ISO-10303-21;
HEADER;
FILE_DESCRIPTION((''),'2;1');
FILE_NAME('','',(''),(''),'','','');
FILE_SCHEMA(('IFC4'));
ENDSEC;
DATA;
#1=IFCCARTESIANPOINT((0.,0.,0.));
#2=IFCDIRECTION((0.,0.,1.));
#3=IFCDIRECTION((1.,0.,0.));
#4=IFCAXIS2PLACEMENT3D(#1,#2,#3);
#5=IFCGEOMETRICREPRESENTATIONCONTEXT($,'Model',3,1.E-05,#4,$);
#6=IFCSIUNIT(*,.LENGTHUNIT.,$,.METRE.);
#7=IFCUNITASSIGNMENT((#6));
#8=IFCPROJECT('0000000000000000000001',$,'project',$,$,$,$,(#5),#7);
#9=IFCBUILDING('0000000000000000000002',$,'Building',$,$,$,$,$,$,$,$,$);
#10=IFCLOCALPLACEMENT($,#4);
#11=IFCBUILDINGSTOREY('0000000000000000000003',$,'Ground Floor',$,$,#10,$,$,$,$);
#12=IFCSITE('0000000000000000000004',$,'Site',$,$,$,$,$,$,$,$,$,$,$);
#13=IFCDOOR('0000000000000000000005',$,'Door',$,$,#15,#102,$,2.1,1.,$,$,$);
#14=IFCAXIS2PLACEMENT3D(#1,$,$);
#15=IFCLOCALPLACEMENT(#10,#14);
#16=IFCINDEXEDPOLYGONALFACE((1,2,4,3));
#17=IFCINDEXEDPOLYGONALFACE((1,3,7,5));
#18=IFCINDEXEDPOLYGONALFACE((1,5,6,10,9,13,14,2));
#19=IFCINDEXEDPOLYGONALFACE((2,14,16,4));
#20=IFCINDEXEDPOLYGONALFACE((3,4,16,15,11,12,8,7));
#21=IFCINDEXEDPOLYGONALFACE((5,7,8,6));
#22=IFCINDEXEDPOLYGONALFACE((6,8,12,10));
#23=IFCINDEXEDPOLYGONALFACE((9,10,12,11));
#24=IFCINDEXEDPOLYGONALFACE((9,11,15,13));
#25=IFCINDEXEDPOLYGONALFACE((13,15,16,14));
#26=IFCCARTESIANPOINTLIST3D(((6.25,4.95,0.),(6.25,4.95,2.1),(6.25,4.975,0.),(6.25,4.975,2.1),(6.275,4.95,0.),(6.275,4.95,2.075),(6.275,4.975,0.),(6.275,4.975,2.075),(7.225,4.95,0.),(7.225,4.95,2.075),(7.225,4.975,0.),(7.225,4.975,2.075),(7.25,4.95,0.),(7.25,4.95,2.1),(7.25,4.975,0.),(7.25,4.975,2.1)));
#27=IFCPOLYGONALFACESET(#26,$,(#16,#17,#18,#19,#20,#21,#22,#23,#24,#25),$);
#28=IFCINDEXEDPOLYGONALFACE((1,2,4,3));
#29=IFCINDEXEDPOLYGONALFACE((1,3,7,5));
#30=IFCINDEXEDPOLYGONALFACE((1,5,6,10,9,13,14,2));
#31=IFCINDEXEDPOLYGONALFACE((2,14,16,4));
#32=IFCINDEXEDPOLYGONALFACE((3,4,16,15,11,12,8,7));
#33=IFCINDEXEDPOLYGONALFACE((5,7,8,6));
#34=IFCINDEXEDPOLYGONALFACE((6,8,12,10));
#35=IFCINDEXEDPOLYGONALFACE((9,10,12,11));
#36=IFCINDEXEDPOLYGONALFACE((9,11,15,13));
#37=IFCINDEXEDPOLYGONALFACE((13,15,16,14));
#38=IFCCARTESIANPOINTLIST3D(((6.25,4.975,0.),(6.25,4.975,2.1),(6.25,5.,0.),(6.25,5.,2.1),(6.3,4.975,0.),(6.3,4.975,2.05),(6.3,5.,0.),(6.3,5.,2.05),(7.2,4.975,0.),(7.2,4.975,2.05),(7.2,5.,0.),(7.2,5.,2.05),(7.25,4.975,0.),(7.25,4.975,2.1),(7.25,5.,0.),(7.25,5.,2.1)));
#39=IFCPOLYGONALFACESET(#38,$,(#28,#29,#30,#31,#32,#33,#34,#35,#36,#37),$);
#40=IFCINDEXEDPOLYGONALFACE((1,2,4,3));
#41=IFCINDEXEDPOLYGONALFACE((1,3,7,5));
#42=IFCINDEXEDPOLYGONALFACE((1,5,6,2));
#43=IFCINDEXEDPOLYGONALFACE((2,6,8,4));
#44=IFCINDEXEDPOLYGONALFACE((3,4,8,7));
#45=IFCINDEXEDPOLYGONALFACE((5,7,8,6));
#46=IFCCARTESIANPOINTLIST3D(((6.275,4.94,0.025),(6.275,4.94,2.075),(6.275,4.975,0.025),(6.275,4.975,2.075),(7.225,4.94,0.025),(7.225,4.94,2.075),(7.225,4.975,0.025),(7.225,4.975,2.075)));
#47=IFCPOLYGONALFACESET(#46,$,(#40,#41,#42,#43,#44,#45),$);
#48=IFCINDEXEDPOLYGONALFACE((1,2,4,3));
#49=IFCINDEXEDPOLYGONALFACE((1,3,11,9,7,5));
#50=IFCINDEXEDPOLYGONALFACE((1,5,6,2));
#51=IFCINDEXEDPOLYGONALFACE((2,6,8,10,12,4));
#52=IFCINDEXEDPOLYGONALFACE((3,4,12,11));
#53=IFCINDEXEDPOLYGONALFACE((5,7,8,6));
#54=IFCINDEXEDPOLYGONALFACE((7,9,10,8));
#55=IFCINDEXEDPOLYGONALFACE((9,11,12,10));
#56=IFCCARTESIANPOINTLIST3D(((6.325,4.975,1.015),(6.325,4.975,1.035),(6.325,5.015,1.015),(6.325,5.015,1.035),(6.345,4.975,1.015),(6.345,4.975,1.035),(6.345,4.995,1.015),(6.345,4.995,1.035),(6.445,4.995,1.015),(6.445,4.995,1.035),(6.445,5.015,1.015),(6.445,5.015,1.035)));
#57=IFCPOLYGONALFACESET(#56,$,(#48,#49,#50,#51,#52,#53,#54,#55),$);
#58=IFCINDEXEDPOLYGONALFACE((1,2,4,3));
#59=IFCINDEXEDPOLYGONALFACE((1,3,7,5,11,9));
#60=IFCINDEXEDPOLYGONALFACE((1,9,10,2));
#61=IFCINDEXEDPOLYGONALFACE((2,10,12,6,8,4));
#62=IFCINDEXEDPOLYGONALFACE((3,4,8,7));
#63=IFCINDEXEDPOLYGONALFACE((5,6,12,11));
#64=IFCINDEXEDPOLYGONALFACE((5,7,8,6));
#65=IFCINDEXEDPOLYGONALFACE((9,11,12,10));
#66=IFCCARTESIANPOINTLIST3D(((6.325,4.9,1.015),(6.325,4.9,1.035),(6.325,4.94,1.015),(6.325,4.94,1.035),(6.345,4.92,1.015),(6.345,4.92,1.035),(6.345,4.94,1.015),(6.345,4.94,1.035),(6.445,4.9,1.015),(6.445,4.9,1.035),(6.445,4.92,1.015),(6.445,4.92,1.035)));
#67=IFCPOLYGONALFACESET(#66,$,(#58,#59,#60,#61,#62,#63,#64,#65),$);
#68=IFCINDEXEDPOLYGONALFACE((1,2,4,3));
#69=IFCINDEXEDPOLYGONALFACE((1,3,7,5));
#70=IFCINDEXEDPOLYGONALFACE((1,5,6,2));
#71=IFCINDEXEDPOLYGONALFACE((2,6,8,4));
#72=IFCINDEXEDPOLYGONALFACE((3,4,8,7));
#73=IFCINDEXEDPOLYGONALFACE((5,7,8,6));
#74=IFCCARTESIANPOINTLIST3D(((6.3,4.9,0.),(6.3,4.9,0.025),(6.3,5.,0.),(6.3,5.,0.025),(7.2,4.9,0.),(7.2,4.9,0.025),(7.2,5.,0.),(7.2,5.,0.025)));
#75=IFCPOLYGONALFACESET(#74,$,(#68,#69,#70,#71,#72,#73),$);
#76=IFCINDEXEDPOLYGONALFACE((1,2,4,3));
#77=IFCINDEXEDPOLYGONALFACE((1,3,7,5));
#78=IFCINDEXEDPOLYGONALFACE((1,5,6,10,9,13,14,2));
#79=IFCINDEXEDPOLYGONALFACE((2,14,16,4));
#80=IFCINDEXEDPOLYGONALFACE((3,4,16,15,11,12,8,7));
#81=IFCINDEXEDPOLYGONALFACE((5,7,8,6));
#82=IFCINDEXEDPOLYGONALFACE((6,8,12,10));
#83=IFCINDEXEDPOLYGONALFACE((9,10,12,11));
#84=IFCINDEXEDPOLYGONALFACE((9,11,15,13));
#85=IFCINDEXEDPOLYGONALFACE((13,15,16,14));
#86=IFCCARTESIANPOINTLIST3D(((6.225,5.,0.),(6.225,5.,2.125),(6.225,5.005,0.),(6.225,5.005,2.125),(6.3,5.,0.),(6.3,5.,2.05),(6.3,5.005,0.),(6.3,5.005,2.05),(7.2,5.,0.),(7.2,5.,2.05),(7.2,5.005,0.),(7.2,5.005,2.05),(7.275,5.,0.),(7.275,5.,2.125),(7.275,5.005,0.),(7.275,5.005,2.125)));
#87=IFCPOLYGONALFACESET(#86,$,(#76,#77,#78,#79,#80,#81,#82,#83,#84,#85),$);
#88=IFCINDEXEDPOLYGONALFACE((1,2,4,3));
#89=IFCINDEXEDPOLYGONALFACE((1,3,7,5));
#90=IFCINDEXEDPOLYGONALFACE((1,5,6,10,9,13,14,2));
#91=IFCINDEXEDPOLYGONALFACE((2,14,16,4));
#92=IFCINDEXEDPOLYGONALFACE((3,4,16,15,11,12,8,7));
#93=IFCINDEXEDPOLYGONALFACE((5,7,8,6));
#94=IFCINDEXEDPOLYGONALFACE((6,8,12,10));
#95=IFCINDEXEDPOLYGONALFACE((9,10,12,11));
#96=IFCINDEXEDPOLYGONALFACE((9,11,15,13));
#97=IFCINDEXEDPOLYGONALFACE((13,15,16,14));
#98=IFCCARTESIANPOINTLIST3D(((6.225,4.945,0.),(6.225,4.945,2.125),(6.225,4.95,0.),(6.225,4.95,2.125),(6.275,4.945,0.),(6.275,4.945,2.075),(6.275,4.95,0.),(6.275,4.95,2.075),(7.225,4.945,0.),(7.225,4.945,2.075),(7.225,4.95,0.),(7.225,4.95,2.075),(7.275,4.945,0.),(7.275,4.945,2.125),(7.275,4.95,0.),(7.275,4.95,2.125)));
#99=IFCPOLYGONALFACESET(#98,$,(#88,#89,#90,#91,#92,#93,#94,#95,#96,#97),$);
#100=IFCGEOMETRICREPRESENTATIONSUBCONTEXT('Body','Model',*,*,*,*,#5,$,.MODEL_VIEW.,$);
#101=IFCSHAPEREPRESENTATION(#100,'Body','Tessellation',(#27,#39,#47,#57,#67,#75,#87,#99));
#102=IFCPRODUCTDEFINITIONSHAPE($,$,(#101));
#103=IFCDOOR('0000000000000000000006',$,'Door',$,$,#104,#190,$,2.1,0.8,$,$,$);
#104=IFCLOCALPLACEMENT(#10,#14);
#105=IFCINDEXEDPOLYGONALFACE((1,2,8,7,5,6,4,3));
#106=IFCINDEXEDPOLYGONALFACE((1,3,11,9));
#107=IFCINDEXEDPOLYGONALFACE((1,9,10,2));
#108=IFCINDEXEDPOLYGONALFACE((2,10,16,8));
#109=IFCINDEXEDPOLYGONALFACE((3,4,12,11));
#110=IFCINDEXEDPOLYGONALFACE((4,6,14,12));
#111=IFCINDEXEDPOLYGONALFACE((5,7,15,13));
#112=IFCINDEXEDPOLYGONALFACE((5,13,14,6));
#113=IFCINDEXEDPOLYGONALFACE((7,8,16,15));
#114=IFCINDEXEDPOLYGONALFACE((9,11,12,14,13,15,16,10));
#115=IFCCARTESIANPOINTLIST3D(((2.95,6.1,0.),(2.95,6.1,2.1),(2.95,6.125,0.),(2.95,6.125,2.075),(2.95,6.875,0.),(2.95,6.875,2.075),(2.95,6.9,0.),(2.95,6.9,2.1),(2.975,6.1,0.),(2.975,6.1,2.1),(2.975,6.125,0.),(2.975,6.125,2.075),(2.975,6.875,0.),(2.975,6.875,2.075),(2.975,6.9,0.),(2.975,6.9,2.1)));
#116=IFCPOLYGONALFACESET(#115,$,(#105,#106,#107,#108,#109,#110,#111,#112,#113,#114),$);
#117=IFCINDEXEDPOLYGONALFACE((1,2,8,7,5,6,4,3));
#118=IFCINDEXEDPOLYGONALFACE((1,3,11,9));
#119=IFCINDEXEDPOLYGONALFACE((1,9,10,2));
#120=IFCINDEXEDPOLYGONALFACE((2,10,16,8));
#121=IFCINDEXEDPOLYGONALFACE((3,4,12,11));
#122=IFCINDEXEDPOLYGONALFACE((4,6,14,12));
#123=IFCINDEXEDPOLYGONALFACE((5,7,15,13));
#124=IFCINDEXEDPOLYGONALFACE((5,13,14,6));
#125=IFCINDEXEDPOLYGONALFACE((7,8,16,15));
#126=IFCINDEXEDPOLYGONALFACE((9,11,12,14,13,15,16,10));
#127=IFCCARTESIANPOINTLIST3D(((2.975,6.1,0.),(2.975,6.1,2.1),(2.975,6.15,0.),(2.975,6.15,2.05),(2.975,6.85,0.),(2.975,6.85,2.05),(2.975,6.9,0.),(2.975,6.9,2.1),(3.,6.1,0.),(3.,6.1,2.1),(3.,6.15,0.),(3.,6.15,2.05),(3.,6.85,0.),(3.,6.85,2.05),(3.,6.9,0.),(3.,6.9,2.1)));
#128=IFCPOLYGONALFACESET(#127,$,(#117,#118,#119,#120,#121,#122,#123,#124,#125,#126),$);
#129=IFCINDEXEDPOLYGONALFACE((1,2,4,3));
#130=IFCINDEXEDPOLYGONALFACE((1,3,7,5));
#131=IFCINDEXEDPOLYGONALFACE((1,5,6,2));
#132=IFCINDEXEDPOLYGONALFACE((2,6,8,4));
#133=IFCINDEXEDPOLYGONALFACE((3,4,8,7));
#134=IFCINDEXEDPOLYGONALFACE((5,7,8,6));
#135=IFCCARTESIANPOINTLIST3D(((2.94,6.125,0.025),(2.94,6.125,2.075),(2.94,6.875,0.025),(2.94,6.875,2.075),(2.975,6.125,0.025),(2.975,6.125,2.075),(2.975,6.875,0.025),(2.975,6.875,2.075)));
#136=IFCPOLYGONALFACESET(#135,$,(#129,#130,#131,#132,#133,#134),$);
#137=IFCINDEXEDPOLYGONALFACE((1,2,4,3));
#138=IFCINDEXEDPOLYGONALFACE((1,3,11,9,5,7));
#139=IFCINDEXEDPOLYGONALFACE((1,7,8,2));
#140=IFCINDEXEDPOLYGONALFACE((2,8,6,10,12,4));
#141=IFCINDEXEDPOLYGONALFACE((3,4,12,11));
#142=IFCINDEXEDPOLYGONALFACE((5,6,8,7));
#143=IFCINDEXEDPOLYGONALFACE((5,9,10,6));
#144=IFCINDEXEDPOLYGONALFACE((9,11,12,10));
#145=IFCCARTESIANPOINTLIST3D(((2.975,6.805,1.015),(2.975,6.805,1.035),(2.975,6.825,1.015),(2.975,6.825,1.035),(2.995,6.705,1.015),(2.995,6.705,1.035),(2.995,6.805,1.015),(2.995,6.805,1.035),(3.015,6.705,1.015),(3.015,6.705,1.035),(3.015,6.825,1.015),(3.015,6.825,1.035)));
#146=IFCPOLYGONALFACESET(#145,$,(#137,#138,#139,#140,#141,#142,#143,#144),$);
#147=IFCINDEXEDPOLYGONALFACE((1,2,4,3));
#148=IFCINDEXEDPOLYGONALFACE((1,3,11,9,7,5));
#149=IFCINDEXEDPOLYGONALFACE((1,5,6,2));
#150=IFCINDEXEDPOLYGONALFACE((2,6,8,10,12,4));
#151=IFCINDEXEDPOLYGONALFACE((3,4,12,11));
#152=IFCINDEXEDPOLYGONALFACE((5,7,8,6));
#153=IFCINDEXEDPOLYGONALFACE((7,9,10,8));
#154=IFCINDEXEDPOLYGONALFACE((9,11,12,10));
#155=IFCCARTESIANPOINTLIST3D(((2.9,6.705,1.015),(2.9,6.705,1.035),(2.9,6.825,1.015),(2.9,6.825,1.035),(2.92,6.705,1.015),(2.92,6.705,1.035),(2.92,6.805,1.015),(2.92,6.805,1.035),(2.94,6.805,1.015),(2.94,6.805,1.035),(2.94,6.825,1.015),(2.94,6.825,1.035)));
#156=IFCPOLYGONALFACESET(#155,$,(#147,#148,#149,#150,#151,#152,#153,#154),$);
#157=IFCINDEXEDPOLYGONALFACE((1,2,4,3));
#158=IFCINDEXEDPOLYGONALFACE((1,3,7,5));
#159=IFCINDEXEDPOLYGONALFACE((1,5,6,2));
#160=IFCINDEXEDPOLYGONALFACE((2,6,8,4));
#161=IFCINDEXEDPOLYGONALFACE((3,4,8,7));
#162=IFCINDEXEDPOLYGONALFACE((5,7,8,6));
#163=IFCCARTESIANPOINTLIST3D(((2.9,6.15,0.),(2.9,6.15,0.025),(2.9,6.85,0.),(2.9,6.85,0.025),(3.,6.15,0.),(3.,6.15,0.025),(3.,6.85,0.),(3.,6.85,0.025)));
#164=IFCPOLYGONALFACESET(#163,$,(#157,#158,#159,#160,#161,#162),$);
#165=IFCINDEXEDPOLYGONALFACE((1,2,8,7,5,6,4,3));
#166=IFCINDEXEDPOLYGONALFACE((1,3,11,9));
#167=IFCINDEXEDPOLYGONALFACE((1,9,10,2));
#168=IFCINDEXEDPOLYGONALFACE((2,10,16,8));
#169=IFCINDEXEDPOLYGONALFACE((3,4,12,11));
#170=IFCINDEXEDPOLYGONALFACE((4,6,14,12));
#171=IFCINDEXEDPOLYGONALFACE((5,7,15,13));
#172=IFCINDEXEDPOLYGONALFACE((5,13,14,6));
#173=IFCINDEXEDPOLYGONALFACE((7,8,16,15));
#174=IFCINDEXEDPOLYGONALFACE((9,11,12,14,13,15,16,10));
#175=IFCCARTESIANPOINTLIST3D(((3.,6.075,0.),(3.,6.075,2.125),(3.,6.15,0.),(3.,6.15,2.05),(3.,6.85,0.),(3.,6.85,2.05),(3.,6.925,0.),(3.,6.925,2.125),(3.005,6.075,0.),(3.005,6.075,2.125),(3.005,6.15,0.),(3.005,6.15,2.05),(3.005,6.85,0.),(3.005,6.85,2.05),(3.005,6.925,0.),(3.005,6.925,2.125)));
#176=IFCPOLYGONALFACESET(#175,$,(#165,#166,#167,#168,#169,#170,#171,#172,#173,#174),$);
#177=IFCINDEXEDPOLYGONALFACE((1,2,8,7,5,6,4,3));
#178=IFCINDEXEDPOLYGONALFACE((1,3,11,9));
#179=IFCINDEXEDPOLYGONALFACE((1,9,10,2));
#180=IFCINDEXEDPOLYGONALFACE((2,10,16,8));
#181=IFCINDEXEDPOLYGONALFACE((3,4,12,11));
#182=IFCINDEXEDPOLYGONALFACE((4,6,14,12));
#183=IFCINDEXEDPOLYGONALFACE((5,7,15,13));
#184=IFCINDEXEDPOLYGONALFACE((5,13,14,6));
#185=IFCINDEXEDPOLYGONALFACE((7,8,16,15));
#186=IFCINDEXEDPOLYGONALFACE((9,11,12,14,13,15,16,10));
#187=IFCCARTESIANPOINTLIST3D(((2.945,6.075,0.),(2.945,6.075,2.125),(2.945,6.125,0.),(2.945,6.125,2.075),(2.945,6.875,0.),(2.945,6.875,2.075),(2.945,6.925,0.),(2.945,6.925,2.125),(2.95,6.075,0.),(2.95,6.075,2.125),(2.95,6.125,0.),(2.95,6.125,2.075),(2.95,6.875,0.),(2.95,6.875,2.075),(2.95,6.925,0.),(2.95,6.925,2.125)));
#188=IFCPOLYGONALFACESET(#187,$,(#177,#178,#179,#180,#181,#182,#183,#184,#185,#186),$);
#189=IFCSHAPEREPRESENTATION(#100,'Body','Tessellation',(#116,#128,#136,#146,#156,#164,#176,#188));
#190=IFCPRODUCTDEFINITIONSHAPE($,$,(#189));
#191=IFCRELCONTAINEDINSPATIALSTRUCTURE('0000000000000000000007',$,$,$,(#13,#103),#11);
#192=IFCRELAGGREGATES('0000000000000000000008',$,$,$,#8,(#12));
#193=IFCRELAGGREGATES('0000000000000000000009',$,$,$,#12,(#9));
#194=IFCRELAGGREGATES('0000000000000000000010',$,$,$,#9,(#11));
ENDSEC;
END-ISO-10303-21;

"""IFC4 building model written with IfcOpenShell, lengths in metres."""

from ifc_helpers import new_model, si_unit, frame, origin_with_axes, place, context, subcontext, project, spatial, line, indexed_curve, outline, extrude, element, save


model = new_model("IFC4")

# Units and contexts
model_context = context("Model", 3, precision=1e-05, world=origin_with_axes())
body_context = subcontext(model_context, "Body", "Model", "MODEL_VIEW")
ifc_project = project(units=[si_unit("LENGTHUNIT", "METRE")], contexts=[model_context])

# Site, building, storey
site = spatial("IfcSite", under=ifc_project, Name="Site")
building = spatial("IfcBuilding", under=site, Name="Building")
storey_placement = place(None, origin_with_axes())
storey = spatial("IfcBuildingStorey", under=building, at=storey_placement, Name="Ground Floor")

# Doors
door_1_placement = place(storey_placement, frame((7.25, 5.0, 0.0), z_axis=(0.0, 0.0, 1.0), x_axis=(-1.0, 0.0, 0.0)))
element("IfcDoor", 1, at=door_1_placement, inside=storey, Name="Door", OverallHeight=2.1, OverallWidth=1.0, context=body_context, shape_type="SweptSolid", body=[
    extrude(outline(indexed_curve([(0.0, 0.0), (0.0, 2.1), (1.0, 2.1), (1.0, 0.0), (0.975, 0.0), (0.975, 2.075), (0.025, 2.075), (0.025, 0.0)], segments=[line(1, 2, 3, 4, 5, 6, 7, 8, 1)])), frame((0.0, 0.025, 0.0), z_axis=(0.0, -1.0, 0.0), x_axis=(1.0, 0.0, 0.0)), (0.0, 0.0, -1.0), 0.025),
    extrude(outline(indexed_curve([(0.0, 0.0), (0.0, 2.1), (1.0, 2.1), (1.0, 0.0), (0.95, 0.0), (0.95, 2.05), (0.05, 2.05), (0.05, 0.0)], segments=[line(1, 2, 3, 4, 5, 6, 7, 8, 1)])), frame((0.0, 0.0, 0.0), z_axis=(0.0, -1.0, 0.0), x_axis=(1.0, 0.0, 0.0)), (0.0, 0.0, -1.0), 0.025),
    extrude(outline(indexed_curve([(0.0, 0.0), (0.95, 0.0), (0.95, 0.035), (0.0, 0.035)], segments=[line(1, 2, 3, 4, 1)])), frame((0.025, 0.025, 0.025), z_axis=(0.0, 0.0, 1.0), x_axis=(1.0, 0.0, 0.0)), (0.0, 0.0, 1.0), 2.05),
    extrude(outline(indexed_curve([(0.0, 0.0), (0.0, -0.04), (-0.12, -0.04), (-0.12, -0.02), (-0.02, -0.02), (-0.02, 0.0)], segments=[line(1, 2, 3, 4, 5, 6, 1)])), frame((0.925, 0.025, 1.015), z_axis=(0.0, 0.0, 1.0), x_axis=(1.0, 0.0, 0.0)), (0.0, 0.0, 1.0), 0.02),
    extrude(outline(indexed_curve([(0.0, 0.0), (0.0, 0.04), (-0.12, 0.04), (-0.12, 0.02), (-0.02, 0.02), (-0.02, 0.0)], segments=[line(1, 2, 3, 4, 5, 6, 1)])), frame((0.925, 0.06, 1.015), z_axis=(0.0, 0.0, 1.0), x_axis=(1.0, 0.0, 0.0)), (0.0, 0.0, 1.0), 0.02),
    extrude(outline(indexed_curve([(0.0, 0.0), (0.9, 0.0), (0.9, 0.1), (0.0, 0.1)], segments=[line(1, 2, 3, 4, 1)])), frame((0.05, 0.0, 0.0), z_axis=(0.0, 0.0, 1.0), x_axis=(1.0, 0.0, 0.0)), (0.0, 0.0, 1.0), 0.025),
    extrude(outline(indexed_curve([(0.0, 0.0), (0.0, 2.125), (1.05, 2.125), (1.05, 0.0), (0.975, 0.0), (0.975, 2.05), (0.075, 2.05), (0.075, 0.0)], segments=[line(1, 2, 3, 4, 5, 6, 7, 8, 1)])), frame((-0.025, -0.005, 0.0), z_axis=(0.0, -1.0, 0.0), x_axis=(1.0, 0.0, 0.0)), (0.0, 0.0, -1.0), 0.005),
    extrude(outline(indexed_curve([(0.0, 0.0), (0.0, 2.125), (1.05, 2.125), (1.05, 0.0), (1.0, 0.0), (1.0, 2.075), (0.05, 2.075), (0.05, 0.0)], segments=[line(1, 2, 3, 4, 5, 6, 7, 8, 1)])), frame((-0.025, 0.05, 0.0), z_axis=(0.0, -1.0, 0.0), x_axis=(1.0, 0.0, 0.0)), (0.0, 0.0, -1.0), 0.005),
])
door_2_placement = place(storey_placement, frame((3.0, 6.1, 0.0), z_axis=(0.0, 0.0, 1.0), x_axis=(0.0, 1.0, 0.0)))
element("IfcDoor", 2, at=door_2_placement, inside=storey, Name="Door", OverallHeight=2.1, OverallWidth=0.8, context=body_context, shape_type="SweptSolid", body=[
    extrude(outline(indexed_curve([(0.0, 0.0), (0.0, 2.1), (0.8, 2.1), (0.8, 0.0), (0.775, 0.0), (0.775, 2.075), (0.025, 2.075), (0.025, 0.0)], segments=[line(1, 2, 3, 4, 5, 6, 7, 8, 1)])), frame((0.0, 0.025, 0.0), z_axis=(0.0, -1.0, 0.0), x_axis=(1.0, 0.0, 0.0)), (0.0, 0.0, -1.0), 0.025),
    extrude(outline(indexed_curve([(0.0, 0.0), (0.0, 2.1), (0.8, 2.1), (0.8, 0.0), (0.75, 0.0), (0.75, 2.05), (0.05, 2.05), (0.05, 0.0)], segments=[line(1, 2, 3, 4, 5, 6, 7, 8, 1)])), frame((0.0, 0.0, 0.0), z_axis=(0.0, -1.0, 0.0), x_axis=(1.0, 0.0, 0.0)), (0.0, 0.0, -1.0), 0.025),
    extrude(outline(indexed_curve([(0.0, 0.0), (0.75, 0.0), (0.75, 0.035), (0.0, 0.035)], segments=[line(1, 2, 3, 4, 1)])), frame((0.025, 0.025, 0.025), z_axis=(0.0, 0.0, 1.0), x_axis=(1.0, 0.0, 0.0)), (0.0, 0.0, 1.0), 2.05),
    extrude(outline(indexed_curve([(0.0, 0.0), (0.0, -0.04), (-0.12, -0.04), (-0.12, -0.02), (-0.02, -0.02), (-0.02, 0.0)], segments=[line(1, 2, 3, 4, 5, 6, 1)])), frame((0.725, 0.025, 1.015), z_axis=(0.0, 0.0, 1.0), x_axis=(1.0, 0.0, 0.0)), (0.0, 0.0, 1.0), 0.02),
    extrude(outline(indexed_curve([(0.0, 0.0), (0.0, 0.04), (-0.12, 0.04), (-0.12, 0.02), (-0.02, 0.02), (-0.02, 0.0)], segments=[line(1, 2, 3, 4, 5, 6, 1)])), frame((0.725, 0.06, 1.015), z_axis=(0.0, 0.0, 1.0), x_axis=(1.0, 0.0, 0.0)), (0.0, 0.0, 1.0), 0.02),
    extrude(outline(indexed_curve([(0.0, 0.0), (0.7, 0.0), (0.7, 0.1), (0.0, 0.1)], segments=[line(1, 2, 3, 4, 1)])), frame((0.05, 0.0, 0.0), z_axis=(0.0, 0.0, 1.0), x_axis=(1.0, 0.0, 0.0)), (0.0, 0.0, 1.0), 0.025),
    extrude(outline(indexed_curve([(0.0, 0.0), (0.0, 2.125), (0.85, 2.125), (0.85, 0.0), (0.775, 0.0), (0.775, 2.05), (0.075, 2.05), (0.075, 0.0)], segments=[line(1, 2, 3, 4, 5, 6, 7, 8, 1)])), frame((-0.025, -0.005, 0.0), z_axis=(0.0, -1.0, 0.0), x_axis=(1.0, 0.0, 0.0)), (0.0, 0.0, -1.0), 0.005),
    extrude(outline(indexed_curve([(0.0, 0.0), (0.0, 2.125), (0.85, 2.125), (0.85, 0.0), (0.8, 0.0), (0.8, 2.075), (0.05, 2.075), (0.05, 0.0)], segments=[line(1, 2, 3, 4, 5, 6, 7, 8, 1)])), frame((-0.025, 0.05, 0.0), z_axis=(0.0, -1.0, 0.0), x_axis=(1.0, 0.0, 0.0)), (0.0, 0.0, -1.0), 0.005),
])

save(model, "model.ifc")
